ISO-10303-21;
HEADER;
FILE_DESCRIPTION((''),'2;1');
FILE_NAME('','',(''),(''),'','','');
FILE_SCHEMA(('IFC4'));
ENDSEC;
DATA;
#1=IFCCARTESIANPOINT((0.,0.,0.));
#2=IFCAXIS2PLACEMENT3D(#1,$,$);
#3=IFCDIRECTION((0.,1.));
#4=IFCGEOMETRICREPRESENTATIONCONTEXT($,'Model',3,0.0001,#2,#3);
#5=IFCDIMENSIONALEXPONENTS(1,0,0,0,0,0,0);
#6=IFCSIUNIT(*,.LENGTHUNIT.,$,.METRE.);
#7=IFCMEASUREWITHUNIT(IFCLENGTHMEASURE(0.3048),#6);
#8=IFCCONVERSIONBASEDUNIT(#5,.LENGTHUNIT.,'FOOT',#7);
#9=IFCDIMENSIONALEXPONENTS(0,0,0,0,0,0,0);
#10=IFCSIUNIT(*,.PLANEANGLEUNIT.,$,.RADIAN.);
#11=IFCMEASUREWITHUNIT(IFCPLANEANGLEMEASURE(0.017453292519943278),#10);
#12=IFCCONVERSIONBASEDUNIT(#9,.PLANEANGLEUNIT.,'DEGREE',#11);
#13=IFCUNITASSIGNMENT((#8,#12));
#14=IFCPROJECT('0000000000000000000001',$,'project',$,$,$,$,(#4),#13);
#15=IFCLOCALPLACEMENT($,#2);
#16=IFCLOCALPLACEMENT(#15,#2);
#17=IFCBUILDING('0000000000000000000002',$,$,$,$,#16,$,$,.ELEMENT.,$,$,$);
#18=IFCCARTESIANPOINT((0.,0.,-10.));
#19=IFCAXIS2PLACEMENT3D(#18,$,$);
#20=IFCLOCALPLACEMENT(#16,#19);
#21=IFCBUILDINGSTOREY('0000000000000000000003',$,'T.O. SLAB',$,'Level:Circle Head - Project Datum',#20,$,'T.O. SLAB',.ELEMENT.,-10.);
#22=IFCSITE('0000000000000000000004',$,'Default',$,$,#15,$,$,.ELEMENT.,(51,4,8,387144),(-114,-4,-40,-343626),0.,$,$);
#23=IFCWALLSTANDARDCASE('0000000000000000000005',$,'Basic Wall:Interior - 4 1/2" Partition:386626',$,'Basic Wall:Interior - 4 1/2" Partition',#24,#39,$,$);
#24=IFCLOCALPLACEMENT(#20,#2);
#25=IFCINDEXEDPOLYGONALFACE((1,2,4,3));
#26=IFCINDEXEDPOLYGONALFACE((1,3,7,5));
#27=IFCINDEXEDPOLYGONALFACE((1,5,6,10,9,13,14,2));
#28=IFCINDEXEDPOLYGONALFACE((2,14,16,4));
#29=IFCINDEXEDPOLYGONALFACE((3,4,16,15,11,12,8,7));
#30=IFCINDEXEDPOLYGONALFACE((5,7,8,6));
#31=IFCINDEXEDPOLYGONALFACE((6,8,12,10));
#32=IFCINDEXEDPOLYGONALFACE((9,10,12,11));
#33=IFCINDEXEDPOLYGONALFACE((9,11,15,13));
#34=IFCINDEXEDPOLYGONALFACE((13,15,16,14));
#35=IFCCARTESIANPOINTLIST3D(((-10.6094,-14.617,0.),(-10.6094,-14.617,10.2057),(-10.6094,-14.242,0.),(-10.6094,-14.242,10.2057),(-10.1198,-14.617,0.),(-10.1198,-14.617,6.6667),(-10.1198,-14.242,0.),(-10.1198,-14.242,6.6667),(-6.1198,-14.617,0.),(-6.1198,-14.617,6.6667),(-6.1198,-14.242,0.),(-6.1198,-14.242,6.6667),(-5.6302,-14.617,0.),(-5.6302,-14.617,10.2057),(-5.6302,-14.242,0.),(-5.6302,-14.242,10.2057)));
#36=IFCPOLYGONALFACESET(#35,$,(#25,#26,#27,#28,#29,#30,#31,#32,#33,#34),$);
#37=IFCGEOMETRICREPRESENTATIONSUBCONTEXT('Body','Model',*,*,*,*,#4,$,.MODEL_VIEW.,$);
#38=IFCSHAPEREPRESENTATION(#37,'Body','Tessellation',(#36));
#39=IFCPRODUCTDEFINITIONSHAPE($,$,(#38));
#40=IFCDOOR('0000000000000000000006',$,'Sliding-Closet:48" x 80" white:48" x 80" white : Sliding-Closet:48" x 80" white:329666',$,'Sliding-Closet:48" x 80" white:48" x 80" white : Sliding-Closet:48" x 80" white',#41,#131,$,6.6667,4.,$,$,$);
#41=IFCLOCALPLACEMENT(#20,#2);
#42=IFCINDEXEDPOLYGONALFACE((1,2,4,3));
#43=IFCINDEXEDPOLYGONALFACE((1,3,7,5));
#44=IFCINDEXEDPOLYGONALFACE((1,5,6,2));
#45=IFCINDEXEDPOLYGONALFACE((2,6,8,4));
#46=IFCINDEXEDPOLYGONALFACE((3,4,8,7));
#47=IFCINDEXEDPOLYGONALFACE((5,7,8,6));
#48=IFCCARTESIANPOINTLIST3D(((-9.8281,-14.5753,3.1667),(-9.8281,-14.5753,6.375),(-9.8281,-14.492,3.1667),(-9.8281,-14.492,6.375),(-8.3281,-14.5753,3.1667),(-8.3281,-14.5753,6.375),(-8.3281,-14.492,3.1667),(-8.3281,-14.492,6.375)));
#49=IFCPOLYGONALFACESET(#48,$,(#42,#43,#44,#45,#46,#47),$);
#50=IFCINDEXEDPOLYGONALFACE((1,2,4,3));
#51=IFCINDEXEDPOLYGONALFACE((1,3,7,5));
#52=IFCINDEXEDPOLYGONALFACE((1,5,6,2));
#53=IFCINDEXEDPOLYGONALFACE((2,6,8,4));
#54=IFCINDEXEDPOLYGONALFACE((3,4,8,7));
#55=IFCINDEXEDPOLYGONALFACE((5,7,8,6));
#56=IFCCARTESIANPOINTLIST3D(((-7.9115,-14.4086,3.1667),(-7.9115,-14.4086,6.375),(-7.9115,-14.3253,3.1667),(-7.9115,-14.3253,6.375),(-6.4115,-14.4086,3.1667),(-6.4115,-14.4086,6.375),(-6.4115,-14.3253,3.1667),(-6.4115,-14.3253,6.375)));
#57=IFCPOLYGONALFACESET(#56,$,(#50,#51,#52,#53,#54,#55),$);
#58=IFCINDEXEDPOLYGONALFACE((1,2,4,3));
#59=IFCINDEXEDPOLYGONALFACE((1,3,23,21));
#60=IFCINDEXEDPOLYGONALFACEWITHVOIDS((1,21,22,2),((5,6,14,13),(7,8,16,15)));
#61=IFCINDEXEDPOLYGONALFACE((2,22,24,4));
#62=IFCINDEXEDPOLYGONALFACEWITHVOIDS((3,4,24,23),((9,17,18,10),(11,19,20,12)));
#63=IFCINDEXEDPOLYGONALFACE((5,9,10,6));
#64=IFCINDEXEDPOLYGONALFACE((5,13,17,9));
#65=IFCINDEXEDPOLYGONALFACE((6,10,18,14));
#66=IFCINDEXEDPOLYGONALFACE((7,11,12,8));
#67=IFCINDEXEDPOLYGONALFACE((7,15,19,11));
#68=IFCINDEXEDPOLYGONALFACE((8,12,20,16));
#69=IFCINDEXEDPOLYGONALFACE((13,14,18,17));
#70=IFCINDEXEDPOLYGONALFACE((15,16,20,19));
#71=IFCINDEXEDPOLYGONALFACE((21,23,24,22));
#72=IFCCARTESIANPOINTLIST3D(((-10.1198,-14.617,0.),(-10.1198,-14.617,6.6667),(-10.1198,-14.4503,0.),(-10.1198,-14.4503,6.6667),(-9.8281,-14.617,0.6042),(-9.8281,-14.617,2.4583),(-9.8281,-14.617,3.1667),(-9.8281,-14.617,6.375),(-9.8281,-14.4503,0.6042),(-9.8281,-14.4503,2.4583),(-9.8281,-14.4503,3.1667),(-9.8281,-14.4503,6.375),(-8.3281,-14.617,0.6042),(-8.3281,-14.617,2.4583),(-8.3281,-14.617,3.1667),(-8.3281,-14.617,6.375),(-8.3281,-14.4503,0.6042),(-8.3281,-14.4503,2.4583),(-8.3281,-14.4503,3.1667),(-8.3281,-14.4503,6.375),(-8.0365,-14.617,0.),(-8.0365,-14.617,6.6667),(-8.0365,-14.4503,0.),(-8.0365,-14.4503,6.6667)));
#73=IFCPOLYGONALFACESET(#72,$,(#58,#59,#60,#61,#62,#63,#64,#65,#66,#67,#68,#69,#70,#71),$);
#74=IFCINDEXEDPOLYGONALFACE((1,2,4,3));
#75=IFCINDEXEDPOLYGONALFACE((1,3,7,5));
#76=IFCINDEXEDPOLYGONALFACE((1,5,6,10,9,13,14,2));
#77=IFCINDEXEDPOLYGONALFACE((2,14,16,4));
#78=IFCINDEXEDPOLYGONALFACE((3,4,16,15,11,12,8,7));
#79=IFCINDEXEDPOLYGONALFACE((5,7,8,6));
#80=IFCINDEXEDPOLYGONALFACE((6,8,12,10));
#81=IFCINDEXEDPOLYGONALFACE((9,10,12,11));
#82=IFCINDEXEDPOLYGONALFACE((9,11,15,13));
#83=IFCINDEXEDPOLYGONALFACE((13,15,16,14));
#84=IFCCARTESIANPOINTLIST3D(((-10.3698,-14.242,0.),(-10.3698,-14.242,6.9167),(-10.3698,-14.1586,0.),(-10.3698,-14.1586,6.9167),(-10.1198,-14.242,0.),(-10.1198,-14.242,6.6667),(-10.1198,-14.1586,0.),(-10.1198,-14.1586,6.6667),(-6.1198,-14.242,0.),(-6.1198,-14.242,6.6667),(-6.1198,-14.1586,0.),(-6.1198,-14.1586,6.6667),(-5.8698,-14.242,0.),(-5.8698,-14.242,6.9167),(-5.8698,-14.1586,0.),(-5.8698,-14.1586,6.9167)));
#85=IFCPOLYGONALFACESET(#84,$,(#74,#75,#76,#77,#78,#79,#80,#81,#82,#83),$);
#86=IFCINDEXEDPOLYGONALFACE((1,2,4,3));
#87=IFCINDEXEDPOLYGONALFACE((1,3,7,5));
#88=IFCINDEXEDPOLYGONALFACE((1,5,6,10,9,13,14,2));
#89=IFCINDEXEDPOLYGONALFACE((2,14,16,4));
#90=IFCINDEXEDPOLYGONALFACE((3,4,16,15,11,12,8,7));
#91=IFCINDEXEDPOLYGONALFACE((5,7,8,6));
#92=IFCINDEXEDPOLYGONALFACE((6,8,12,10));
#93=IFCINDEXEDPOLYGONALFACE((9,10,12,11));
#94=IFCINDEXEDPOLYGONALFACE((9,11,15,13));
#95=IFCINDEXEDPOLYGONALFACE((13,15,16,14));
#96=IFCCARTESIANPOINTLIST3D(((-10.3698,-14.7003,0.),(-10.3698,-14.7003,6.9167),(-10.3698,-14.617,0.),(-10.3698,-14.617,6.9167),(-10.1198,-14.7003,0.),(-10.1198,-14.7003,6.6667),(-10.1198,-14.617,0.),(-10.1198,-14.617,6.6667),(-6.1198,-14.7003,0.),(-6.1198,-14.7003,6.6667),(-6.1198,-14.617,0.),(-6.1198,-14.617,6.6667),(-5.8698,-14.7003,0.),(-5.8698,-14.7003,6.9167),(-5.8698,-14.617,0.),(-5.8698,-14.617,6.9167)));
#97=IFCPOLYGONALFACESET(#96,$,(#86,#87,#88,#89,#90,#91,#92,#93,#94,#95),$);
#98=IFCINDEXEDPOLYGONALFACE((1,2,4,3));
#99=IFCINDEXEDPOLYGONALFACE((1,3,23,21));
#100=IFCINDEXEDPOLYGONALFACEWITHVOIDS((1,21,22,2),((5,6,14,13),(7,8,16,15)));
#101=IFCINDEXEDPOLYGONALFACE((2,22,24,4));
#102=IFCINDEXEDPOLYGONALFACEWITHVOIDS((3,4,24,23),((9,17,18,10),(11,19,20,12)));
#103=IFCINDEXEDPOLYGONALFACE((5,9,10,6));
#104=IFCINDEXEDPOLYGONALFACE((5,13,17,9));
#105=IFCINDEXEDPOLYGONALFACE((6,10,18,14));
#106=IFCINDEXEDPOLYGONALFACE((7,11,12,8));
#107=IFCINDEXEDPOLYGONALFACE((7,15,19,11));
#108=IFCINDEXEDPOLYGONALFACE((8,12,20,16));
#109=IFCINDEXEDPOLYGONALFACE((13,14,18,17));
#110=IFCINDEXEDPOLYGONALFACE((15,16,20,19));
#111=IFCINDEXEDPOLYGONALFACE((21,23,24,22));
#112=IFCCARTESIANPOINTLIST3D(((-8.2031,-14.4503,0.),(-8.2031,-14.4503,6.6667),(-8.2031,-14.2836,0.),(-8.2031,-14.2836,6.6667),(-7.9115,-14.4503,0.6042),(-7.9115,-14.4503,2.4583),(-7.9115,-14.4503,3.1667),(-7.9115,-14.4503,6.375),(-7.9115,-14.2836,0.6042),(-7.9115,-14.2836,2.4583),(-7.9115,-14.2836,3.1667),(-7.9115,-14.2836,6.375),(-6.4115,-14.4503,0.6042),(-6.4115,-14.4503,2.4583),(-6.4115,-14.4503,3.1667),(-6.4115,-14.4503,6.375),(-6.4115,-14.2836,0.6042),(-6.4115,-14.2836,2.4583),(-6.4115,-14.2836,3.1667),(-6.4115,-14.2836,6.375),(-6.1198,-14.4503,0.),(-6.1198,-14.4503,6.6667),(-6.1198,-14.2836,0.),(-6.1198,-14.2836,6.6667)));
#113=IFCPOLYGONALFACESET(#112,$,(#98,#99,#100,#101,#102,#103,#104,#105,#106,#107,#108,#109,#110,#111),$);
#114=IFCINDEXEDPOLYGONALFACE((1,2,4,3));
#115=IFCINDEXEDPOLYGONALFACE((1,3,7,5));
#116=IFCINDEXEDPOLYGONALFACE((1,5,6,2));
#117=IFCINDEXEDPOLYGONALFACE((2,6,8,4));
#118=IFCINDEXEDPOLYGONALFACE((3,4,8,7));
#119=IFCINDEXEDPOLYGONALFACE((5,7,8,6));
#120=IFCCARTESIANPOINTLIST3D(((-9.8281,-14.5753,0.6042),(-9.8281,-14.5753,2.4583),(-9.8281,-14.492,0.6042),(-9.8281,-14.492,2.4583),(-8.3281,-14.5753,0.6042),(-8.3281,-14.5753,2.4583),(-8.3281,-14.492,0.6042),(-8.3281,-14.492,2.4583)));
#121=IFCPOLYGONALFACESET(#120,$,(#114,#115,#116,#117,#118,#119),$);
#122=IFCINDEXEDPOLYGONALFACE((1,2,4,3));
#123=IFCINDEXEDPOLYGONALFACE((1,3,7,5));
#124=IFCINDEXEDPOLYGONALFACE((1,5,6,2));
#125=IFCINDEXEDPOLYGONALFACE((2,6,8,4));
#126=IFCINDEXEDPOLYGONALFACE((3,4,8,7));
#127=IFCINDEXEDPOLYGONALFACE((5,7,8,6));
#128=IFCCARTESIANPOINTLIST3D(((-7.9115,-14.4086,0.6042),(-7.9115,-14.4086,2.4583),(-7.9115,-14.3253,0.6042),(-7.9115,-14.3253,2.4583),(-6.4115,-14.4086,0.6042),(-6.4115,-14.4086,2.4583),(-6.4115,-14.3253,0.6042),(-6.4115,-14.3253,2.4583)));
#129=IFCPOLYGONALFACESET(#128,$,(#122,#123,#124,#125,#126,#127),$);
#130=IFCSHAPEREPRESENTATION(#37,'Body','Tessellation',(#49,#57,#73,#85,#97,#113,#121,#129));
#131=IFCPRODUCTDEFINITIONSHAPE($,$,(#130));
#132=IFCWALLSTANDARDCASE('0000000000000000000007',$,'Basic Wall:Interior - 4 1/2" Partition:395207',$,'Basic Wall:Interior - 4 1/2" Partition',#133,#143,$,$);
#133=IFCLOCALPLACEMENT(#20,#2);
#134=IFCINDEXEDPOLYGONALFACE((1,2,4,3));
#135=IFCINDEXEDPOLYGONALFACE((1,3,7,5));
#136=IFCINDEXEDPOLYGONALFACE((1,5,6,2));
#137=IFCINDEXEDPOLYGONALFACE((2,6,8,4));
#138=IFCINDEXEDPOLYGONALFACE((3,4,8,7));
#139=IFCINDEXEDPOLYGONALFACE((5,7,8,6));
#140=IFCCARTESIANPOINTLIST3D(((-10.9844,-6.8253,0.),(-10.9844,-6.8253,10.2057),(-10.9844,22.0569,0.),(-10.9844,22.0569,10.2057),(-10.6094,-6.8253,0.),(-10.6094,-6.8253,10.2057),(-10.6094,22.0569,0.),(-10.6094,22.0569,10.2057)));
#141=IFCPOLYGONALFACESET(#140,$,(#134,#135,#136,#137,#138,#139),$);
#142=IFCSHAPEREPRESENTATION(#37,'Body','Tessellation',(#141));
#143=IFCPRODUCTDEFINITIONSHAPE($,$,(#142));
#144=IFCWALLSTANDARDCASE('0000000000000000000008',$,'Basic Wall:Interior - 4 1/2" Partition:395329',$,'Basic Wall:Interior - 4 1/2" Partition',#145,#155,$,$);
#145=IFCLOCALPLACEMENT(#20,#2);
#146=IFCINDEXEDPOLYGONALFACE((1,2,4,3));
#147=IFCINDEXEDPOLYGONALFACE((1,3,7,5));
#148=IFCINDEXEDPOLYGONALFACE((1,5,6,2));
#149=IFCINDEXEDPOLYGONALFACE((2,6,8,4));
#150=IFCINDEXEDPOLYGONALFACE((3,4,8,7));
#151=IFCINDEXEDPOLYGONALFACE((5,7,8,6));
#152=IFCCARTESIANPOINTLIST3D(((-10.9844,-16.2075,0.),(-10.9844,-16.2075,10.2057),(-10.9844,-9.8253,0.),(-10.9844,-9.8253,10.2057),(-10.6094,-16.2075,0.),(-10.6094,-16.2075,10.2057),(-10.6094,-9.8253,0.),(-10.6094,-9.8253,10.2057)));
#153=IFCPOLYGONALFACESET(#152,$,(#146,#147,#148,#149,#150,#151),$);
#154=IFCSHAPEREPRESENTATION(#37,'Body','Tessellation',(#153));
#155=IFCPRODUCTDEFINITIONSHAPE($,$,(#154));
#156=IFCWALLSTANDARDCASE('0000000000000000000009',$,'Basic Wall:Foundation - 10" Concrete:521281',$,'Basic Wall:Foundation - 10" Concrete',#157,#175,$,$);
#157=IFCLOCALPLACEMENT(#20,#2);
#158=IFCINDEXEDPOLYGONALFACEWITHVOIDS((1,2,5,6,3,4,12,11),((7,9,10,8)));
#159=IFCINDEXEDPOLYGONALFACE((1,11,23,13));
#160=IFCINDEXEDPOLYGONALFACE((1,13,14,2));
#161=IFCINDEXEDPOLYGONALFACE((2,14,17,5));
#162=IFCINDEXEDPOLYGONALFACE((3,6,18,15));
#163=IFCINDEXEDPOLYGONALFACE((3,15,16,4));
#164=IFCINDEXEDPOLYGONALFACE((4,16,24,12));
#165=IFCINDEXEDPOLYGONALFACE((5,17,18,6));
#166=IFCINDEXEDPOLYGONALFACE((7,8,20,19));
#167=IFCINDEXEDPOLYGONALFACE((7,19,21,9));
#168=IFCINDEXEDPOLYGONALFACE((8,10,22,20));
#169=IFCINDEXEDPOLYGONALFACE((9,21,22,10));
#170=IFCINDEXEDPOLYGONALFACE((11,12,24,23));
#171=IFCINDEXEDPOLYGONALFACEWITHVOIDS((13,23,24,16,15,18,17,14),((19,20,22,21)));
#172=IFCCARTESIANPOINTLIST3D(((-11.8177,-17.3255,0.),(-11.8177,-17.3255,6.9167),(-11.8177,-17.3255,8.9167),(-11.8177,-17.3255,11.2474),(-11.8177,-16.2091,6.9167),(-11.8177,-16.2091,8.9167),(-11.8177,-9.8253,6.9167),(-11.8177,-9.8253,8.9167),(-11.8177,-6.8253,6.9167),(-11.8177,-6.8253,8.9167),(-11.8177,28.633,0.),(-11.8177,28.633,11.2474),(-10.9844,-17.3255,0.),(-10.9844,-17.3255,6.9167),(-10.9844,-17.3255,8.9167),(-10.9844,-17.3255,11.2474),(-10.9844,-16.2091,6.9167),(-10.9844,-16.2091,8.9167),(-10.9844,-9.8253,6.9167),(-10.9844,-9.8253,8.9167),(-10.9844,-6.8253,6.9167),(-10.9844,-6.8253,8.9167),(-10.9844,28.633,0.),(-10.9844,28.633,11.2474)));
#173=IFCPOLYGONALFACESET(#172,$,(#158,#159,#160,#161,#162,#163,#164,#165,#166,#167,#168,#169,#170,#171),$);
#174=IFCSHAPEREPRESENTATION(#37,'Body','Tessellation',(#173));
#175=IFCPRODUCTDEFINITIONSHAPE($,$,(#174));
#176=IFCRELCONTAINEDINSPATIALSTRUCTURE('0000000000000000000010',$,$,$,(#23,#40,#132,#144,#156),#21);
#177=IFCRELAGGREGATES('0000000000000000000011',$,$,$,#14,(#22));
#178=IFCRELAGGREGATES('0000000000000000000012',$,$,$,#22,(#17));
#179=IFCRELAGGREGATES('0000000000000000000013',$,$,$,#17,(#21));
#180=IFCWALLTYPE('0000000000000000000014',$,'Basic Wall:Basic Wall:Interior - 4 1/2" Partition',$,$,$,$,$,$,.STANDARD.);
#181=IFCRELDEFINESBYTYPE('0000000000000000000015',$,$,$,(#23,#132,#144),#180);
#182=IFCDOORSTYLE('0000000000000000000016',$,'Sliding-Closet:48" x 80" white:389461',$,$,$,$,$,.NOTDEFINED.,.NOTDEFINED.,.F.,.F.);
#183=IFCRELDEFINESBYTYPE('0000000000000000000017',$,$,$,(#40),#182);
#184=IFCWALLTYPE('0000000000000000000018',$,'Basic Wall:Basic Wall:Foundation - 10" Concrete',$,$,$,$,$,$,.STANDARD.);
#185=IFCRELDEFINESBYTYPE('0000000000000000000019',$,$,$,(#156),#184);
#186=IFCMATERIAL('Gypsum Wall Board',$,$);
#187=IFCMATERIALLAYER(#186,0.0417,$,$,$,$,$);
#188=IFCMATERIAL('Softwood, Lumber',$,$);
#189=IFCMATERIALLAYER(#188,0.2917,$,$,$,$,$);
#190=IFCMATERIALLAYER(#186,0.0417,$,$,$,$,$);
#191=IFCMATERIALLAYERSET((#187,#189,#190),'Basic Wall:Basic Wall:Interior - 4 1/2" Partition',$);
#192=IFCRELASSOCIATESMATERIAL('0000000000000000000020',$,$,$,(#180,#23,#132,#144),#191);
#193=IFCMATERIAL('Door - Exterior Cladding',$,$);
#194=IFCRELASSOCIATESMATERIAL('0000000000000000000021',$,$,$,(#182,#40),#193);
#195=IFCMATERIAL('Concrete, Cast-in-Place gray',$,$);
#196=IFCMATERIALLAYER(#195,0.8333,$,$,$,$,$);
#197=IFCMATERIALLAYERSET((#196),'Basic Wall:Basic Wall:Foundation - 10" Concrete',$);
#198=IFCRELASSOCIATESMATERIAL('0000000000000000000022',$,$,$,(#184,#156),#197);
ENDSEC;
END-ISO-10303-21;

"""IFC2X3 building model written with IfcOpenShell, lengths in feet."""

from ifc_helpers import new_model, entity, si_unit, converted_unit, direction, frame, frame_2d, origin, origin_2d_with_axis, place, context, subcontext, project, spatial, polyline, rectangle, outline, extrude, source, transform, mapped, material, layer, layer_set, layer_usage, type_object, type_shapes, element, fill, save


model = new_model("IFC2X3")

# Units and contexts
model_context = context("Model", 3, precision=0.0001, world=origin(), true_north=direction((0.0, 1.0)))
body_context = subcontext(model_context, "Body", "Model", "MODEL_VIEW")
ifc_project = project(units=[converted_unit("LENGTHUNIT", "FOOT", entity("IfcLengthMeasure", 0.3048), si_unit("LENGTHUNIT", "METRE"), dimensions=[1, 0, 0, 0, 0, 0, 0]), converted_unit("PLANEANGLEUNIT", "DEGREE", entity("IfcPlaneAngleMeasure", 0.017453292519943278), si_unit("PLANEANGLEUNIT", "RADIAN"), dimensions=[0, 0, 0, 0, 0, 0, 0])], contexts=[model_context])

# Site, building, storey
site_placement = place(None, origin())
site = spatial("IfcSite", under=ifc_project, at=site_placement, Name="Default", CompositionType="ELEMENT", RefLatitude=(51, 4, 8, 387144), RefLongitude=(-114, -4, -40, -343626), RefElevation=0.0)
building_placement = place(site_placement, origin())
building = spatial("IfcBuilding", under=site, at=building_placement, CompositionType="ELEMENT")
storey_placement = place(building_placement, frame((0.0, 0.0, -10.0)))
storey = spatial("IfcBuildingStorey", under=building, at=storey_placement, Name="T.O. SLAB", ObjectType="Level:Circle Head - Project Datum", LongName="T.O. SLAB", CompositionType="ELEMENT", Elevation=-10.0)

# Shared definitions
ifc_material_1 = material(Name="Gypsum Wall Board")
ifc_layer_1 = layer(ifc_material_1, 0.0417)
ifc_material_2 = material(Name="Softwood, Lumber")
ifc_layer_2 = layer(ifc_material_2, 0.2917)
ifc_layer_3 = layer(ifc_material_1, 0.0417)
ifc_layer_set_1 = layer_set([ifc_layer_1, ifc_layer_2, ifc_layer_3], Name="Basic Wall:Basic Wall:Interior - 4 1/2\" Partition")
wall_type_1 = type_object("IfcWallType", Name="Basic Wall:Basic Wall:Interior - 4 1/2\" Partition", PredefinedType="STANDARD", material=ifc_layer_set_1)

# Shared definitions
ifc_material_3 = material(Name="Door - Exterior Cladding")

# Wall, opening, door
ifc_layer_usage_1 = layer_usage(ifc_layer_set_1, "AXIS2", "NEGATIVE", 0.1875)
wall_1_placement = place(storey_placement, frame((-5.6302, -14.4295, 0.0), z_axis=(0.0, 0.0, 1.0), x_axis=(-1.0, 0.0, 0.0)))
wall_1 = element("IfcWallStandardCase", 1, at=wall_1_placement, inside=storey, type_object=wall_type_1, material=ifc_layer_usage_1, Name="Basic Wall:Interior - 4 1/2\" Partition:386626", ObjectType="Basic Wall:Interior - 4 1/2\" Partition", context=body_context, shape_type="SweptSolid", body=[
    extrude(rectangle(XDim=4.9792, YDim=0.375, at=frame_2d((2.4896, 0.0), x_axis=(1.0, 0.0))), origin(), (0.0, 0.0, 1.0), 10.2057),
])
opening_1_placement = place(wall_1_placement, frame((-5.6302, -14.4295, 0.0), z_axis=(0.0, 0.0, 1.0), x_axis=(-1.0, 0.0, 0.0)))
opening_1 = element("IfcOpeningElement", 2, at=opening_1_placement, cuts=wall_1, ObjectType="Opening", context=body_context, shape_type="SweptSolid", body=[
    extrude(rectangle(XDim=6.6667, YDim=4.0, at=frame_2d((0.0, 0.0), x_axis=(0.0, 1.0))), frame((-8.1198, -14.2382, 3.3333), z_axis=(0.0, -1.0, 0.0), x_axis=(1.0, 0.0, 0.0)), (0.0, 0.0, 1.0), 0.3825),
])
door_style_1 = type_object("IfcDoorStyle", Name="Sliding-Closet:48\" x 80\" white:389461", ConstructionType="NOTDEFINED", OperationType="NOTDEFINED", ParameterTakesPrecedence=False, Sizeable=False, material=ifc_material_3)
shared_shape_1 = source(origin(), body_context, "Body", "SweptSolid", [
    extrude(rectangle(XDim=0.0833, YDim=1.5, at=origin_2d_with_axis()), frame((2.9583, -0.0871, 3.1667), z_axis=(0.0, 0.0, 1.0), x_axis=(0.0, 1.0, 0.0)), (0.0, 0.0, 1.0), 3.2083),
    extrude(rectangle(XDim=0.0833, YDim=1.5, at=origin_2d_with_axis()), frame((1.0417, -0.2538, 3.1667), z_axis=(0.0, 0.0, 1.0), x_axis=(0.0, -1.0, 0.0)), (0.0, 0.0, 1.0), 3.2083),
    extrude(outline(polyline([(-3.3333, -1.0417), (3.3333, -1.0417), (3.3333, 1.0417), (-3.3333, 1.0417), (-3.3333, -1.0417)]), holes=[polyline([(-0.1667, -0.75), (-0.1667, 0.75), (3.0417, 0.75), (3.0417, -0.75), (-0.1667, -0.75)]), polyline([(-2.7292, -0.75), (-2.7292, 0.75), (-0.875, 0.75), (-0.875, -0.75), (-2.7292, -0.75)])]), frame((2.9583, -0.1704, 3.3333), z_axis=(0.0, 1.0, 0.0), x_axis=(0.0, 0.0, 1.0)), (0.0, 0.0, 1.0), 0.1667),
    extrude(outline(polyline([(-3.5208, -2.25), (3.3958, -2.25), (3.3958, -2.0), (-3.2708, -2.0), (-3.2708, 2.0), (3.3958, 2.0), (3.3958, 2.25), (-3.5208, 2.25), (-3.5208, -2.25)])), frame((2.0, -0.4621, 3.3958), z_axis=(0.0, 1.0, 0.0), x_axis=(0.0, 0.0, -1.0)), (0.0, 0.0, 1.0), 0.0833),
    extrude(outline(polyline([(2.0, -3.3958), (2.25, -3.3958), (2.25, 3.5208), (-2.25, 3.5208), (-2.25, -3.3958), (-2.0, -3.3958), (-2.0, 3.2708), (2.0, 3.2708), (2.0, -3.3958)])), frame((2.0, -0.0037, 3.3958), z_axis=(0.0, 1.0, 0.0), x_axis=(-1.0, 0.0, 0.0)), (0.0, 0.0, 1.0), 0.0833),
    extrude(outline(polyline([(-1.0417, -3.3333), (1.0417, -3.3333), (1.0417, 3.3333), (-1.0417, 3.3333), (-1.0417, -3.3333)]), holes=[polyline([(-0.75, 0.875), (-0.75, 2.7292), (0.75, 2.7292), (0.75, 0.875), (-0.75, 0.875)]), polyline([(-0.75, -3.0417), (-0.75, 0.1667), (0.75, 0.1667), (0.75, -3.0417), (-0.75, -3.0417)])]), frame((1.0417, -0.3371, 3.3333), z_axis=(0.0, 1.0, 0.0), x_axis=(1.0, 0.0, 0.0)), (0.0, 0.0, 1.0), 0.1667),
    extrude(rectangle(XDim=0.0833, YDim=1.5, at=origin_2d_with_axis()), frame((2.9583, -0.0871, 0.6042), z_axis=(0.0, 0.0, 1.0), x_axis=(0.0, 1.0, 0.0)), (0.0, 0.0, 1.0), 1.8542),
    extrude(rectangle(XDim=0.0833, YDim=1.5, at=origin_2d_with_axis()), frame((1.0417, -0.2538, 0.6042), z_axis=(0.0, 0.0, 1.0), x_axis=(0.0, -1.0, 0.0)), (0.0, 0.0, 1.0), 1.8542),
])
type_shapes(door_style_1, [shared_shape_1])
door_1_placement = place(opening_1_placement, frame((-6.1198, -14.6207, 0.0), z_axis=(0.0, 0.0, 1.0), x_axis=(-1.0, 0.0, 0.0)))
door_1 = element("IfcDoor", 3, at=door_1_placement, inside=storey, type_object=door_style_1, material=ifc_material_3, Name="Sliding-Closet:48\" x 80\" white:48\" x 80\" white : Sliding-Closet:48\" x 80\" white:329666", ObjectType="Sliding-Closet:48\" x 80\" white:48\" x 80\" white : Sliding-Closet:48\" x 80\" white", OverallHeight=6.6667, OverallWidth=4.0, context=body_context, shape_type="MappedRepresentation", body=[
    mapped(shared_shape_1, transform((0.0, 0.0, 0.0), scale=1.0)),
])
fill(opening_1, door_1)

# Walls
ifc_layer_usage_2 = layer_usage(ifc_layer_set_1, "AXIS2", "NEGATIVE", 0.1875)
wall_2_placement = place(storey_placement, frame((-10.7969, -6.8253, 0.0), z_axis=(0.0, 0.0, 1.0), x_axis=(0.0, 1.0, 0.0)))
element("IfcWallStandardCase", 4, at=wall_2_placement, inside=storey, type_object=wall_type_1, material=ifc_layer_usage_2, Name="Basic Wall:Interior - 4 1/2\" Partition:395207", ObjectType="Basic Wall:Interior - 4 1/2\" Partition", context=body_context, shape_type="SweptSolid", body=[
    extrude(rectangle(XDim=28.8822, YDim=0.375, at=frame_2d((14.4411, 0.0), x_axis=(-1.0, 0.0))), origin(), (0.0, 0.0, 1.0), 10.2057),
])
ifc_layer_usage_3 = layer_usage(ifc_layer_set_1, "AXIS2", "NEGATIVE", 0.1875)
wall_3_placement = place(storey_placement, frame((-10.7969, -16.2075, 0.0), z_axis=(0.0, 0.0, 1.0), x_axis=(0.0, 1.0, 0.0)))
element("IfcWallStandardCase", 5, at=wall_3_placement, inside=storey, type_object=wall_type_1, material=ifc_layer_usage_3, Name="Basic Wall:Interior - 4 1/2\" Partition:395329", ObjectType="Basic Wall:Interior - 4 1/2\" Partition", context=body_context, shape_type="SweptSolid", body=[
    extrude(rectangle(XDim=6.3822, YDim=0.375, at=frame_2d((3.1911, 0.0), x_axis=(-1.0, 0.0))), origin(), (0.0, 0.0, 1.0), 10.2057),
])

# Wall, openings
ifc_material_4 = material(Name="Concrete, Cast-in-Place gray")
ifc_layer_4 = layer(ifc_material_4, 0.8333)
ifc_layer_set_2 = layer_set([ifc_layer_4], Name="Basic Wall:Basic Wall:Foundation - 10\" Concrete")
ifc_layer_usage_4 = layer_usage(ifc_layer_set_2, "AXIS2", "NEGATIVE", 0.4167)
wall_type_2 = type_object("IfcWallType", Name="Basic Wall:Basic Wall:Foundation - 10\" Concrete", PredefinedType="STANDARD", material=ifc_layer_set_2)
wall_4_placement = place(storey_placement, frame((-11.401, -17.3255, 0.0), z_axis=(0.0, 0.0, 1.0), x_axis=(0.0, 1.0, 0.0)))
wall_4 = element("IfcWallStandardCase", 6, at=wall_4_placement, inside=storey, type_object=wall_type_2, material=ifc_layer_usage_4, Name="Basic Wall:Foundation - 10\" Concrete:521281", ObjectType="Basic Wall:Foundation - 10\" Concrete", context=body_context, shape_type="SweptSolid", body=[
    extrude(rectangle(XDim=45.9585, YDim=0.8333, at=frame_2d((22.9792, 0.0), x_axis=(-1.0, 0.0))), origin(), (0.0, 0.0, 1.0), 11.2474),
])
opening_2_placement = place(wall_4_placement, origin())
element("IfcOpeningElement", 7, at=opening_2_placement, cuts=wall_4, ObjectType="Opening", context=body_context, shape_type="SweptSolid", body=[
    extrude(rectangle(XDim=2.0, YDim=3.0, at=origin_2d_with_axis()), frame((-0.3836, -0.4167, 7.9167), z_axis=(0.0, 1.0, 0.0), x_axis=(0.0, 0.0, -1.0)), (0.0, 0.0, 1.0), 0.8333),
])
opening_3_placement = place(wall_4_placement, frame((17.3255, -11.401, 0.0), z_axis=(0.0, 0.0, 1.0), x_axis=(0.0, -1.0, 0.0)))
element("IfcOpeningElement", 8, at=opening_3_placement, cuts=wall_4, ObjectType="Opening", context=body_context, shape_type="SweptSolid", body=[
    extrude(rectangle(XDim=2.0, YDim=3.0, at=frame_2d((0.0, 0.0), x_axis=(1.0, 0.0))), frame((-10.976, -8.3253, 7.9167), z_axis=(-1.0, 0.0, 0.0), x_axis=(0.0, 0.0, 1.0)), (0.0, 0.0, 1.0), 0.85),
])

save(model, "model.ifc")
